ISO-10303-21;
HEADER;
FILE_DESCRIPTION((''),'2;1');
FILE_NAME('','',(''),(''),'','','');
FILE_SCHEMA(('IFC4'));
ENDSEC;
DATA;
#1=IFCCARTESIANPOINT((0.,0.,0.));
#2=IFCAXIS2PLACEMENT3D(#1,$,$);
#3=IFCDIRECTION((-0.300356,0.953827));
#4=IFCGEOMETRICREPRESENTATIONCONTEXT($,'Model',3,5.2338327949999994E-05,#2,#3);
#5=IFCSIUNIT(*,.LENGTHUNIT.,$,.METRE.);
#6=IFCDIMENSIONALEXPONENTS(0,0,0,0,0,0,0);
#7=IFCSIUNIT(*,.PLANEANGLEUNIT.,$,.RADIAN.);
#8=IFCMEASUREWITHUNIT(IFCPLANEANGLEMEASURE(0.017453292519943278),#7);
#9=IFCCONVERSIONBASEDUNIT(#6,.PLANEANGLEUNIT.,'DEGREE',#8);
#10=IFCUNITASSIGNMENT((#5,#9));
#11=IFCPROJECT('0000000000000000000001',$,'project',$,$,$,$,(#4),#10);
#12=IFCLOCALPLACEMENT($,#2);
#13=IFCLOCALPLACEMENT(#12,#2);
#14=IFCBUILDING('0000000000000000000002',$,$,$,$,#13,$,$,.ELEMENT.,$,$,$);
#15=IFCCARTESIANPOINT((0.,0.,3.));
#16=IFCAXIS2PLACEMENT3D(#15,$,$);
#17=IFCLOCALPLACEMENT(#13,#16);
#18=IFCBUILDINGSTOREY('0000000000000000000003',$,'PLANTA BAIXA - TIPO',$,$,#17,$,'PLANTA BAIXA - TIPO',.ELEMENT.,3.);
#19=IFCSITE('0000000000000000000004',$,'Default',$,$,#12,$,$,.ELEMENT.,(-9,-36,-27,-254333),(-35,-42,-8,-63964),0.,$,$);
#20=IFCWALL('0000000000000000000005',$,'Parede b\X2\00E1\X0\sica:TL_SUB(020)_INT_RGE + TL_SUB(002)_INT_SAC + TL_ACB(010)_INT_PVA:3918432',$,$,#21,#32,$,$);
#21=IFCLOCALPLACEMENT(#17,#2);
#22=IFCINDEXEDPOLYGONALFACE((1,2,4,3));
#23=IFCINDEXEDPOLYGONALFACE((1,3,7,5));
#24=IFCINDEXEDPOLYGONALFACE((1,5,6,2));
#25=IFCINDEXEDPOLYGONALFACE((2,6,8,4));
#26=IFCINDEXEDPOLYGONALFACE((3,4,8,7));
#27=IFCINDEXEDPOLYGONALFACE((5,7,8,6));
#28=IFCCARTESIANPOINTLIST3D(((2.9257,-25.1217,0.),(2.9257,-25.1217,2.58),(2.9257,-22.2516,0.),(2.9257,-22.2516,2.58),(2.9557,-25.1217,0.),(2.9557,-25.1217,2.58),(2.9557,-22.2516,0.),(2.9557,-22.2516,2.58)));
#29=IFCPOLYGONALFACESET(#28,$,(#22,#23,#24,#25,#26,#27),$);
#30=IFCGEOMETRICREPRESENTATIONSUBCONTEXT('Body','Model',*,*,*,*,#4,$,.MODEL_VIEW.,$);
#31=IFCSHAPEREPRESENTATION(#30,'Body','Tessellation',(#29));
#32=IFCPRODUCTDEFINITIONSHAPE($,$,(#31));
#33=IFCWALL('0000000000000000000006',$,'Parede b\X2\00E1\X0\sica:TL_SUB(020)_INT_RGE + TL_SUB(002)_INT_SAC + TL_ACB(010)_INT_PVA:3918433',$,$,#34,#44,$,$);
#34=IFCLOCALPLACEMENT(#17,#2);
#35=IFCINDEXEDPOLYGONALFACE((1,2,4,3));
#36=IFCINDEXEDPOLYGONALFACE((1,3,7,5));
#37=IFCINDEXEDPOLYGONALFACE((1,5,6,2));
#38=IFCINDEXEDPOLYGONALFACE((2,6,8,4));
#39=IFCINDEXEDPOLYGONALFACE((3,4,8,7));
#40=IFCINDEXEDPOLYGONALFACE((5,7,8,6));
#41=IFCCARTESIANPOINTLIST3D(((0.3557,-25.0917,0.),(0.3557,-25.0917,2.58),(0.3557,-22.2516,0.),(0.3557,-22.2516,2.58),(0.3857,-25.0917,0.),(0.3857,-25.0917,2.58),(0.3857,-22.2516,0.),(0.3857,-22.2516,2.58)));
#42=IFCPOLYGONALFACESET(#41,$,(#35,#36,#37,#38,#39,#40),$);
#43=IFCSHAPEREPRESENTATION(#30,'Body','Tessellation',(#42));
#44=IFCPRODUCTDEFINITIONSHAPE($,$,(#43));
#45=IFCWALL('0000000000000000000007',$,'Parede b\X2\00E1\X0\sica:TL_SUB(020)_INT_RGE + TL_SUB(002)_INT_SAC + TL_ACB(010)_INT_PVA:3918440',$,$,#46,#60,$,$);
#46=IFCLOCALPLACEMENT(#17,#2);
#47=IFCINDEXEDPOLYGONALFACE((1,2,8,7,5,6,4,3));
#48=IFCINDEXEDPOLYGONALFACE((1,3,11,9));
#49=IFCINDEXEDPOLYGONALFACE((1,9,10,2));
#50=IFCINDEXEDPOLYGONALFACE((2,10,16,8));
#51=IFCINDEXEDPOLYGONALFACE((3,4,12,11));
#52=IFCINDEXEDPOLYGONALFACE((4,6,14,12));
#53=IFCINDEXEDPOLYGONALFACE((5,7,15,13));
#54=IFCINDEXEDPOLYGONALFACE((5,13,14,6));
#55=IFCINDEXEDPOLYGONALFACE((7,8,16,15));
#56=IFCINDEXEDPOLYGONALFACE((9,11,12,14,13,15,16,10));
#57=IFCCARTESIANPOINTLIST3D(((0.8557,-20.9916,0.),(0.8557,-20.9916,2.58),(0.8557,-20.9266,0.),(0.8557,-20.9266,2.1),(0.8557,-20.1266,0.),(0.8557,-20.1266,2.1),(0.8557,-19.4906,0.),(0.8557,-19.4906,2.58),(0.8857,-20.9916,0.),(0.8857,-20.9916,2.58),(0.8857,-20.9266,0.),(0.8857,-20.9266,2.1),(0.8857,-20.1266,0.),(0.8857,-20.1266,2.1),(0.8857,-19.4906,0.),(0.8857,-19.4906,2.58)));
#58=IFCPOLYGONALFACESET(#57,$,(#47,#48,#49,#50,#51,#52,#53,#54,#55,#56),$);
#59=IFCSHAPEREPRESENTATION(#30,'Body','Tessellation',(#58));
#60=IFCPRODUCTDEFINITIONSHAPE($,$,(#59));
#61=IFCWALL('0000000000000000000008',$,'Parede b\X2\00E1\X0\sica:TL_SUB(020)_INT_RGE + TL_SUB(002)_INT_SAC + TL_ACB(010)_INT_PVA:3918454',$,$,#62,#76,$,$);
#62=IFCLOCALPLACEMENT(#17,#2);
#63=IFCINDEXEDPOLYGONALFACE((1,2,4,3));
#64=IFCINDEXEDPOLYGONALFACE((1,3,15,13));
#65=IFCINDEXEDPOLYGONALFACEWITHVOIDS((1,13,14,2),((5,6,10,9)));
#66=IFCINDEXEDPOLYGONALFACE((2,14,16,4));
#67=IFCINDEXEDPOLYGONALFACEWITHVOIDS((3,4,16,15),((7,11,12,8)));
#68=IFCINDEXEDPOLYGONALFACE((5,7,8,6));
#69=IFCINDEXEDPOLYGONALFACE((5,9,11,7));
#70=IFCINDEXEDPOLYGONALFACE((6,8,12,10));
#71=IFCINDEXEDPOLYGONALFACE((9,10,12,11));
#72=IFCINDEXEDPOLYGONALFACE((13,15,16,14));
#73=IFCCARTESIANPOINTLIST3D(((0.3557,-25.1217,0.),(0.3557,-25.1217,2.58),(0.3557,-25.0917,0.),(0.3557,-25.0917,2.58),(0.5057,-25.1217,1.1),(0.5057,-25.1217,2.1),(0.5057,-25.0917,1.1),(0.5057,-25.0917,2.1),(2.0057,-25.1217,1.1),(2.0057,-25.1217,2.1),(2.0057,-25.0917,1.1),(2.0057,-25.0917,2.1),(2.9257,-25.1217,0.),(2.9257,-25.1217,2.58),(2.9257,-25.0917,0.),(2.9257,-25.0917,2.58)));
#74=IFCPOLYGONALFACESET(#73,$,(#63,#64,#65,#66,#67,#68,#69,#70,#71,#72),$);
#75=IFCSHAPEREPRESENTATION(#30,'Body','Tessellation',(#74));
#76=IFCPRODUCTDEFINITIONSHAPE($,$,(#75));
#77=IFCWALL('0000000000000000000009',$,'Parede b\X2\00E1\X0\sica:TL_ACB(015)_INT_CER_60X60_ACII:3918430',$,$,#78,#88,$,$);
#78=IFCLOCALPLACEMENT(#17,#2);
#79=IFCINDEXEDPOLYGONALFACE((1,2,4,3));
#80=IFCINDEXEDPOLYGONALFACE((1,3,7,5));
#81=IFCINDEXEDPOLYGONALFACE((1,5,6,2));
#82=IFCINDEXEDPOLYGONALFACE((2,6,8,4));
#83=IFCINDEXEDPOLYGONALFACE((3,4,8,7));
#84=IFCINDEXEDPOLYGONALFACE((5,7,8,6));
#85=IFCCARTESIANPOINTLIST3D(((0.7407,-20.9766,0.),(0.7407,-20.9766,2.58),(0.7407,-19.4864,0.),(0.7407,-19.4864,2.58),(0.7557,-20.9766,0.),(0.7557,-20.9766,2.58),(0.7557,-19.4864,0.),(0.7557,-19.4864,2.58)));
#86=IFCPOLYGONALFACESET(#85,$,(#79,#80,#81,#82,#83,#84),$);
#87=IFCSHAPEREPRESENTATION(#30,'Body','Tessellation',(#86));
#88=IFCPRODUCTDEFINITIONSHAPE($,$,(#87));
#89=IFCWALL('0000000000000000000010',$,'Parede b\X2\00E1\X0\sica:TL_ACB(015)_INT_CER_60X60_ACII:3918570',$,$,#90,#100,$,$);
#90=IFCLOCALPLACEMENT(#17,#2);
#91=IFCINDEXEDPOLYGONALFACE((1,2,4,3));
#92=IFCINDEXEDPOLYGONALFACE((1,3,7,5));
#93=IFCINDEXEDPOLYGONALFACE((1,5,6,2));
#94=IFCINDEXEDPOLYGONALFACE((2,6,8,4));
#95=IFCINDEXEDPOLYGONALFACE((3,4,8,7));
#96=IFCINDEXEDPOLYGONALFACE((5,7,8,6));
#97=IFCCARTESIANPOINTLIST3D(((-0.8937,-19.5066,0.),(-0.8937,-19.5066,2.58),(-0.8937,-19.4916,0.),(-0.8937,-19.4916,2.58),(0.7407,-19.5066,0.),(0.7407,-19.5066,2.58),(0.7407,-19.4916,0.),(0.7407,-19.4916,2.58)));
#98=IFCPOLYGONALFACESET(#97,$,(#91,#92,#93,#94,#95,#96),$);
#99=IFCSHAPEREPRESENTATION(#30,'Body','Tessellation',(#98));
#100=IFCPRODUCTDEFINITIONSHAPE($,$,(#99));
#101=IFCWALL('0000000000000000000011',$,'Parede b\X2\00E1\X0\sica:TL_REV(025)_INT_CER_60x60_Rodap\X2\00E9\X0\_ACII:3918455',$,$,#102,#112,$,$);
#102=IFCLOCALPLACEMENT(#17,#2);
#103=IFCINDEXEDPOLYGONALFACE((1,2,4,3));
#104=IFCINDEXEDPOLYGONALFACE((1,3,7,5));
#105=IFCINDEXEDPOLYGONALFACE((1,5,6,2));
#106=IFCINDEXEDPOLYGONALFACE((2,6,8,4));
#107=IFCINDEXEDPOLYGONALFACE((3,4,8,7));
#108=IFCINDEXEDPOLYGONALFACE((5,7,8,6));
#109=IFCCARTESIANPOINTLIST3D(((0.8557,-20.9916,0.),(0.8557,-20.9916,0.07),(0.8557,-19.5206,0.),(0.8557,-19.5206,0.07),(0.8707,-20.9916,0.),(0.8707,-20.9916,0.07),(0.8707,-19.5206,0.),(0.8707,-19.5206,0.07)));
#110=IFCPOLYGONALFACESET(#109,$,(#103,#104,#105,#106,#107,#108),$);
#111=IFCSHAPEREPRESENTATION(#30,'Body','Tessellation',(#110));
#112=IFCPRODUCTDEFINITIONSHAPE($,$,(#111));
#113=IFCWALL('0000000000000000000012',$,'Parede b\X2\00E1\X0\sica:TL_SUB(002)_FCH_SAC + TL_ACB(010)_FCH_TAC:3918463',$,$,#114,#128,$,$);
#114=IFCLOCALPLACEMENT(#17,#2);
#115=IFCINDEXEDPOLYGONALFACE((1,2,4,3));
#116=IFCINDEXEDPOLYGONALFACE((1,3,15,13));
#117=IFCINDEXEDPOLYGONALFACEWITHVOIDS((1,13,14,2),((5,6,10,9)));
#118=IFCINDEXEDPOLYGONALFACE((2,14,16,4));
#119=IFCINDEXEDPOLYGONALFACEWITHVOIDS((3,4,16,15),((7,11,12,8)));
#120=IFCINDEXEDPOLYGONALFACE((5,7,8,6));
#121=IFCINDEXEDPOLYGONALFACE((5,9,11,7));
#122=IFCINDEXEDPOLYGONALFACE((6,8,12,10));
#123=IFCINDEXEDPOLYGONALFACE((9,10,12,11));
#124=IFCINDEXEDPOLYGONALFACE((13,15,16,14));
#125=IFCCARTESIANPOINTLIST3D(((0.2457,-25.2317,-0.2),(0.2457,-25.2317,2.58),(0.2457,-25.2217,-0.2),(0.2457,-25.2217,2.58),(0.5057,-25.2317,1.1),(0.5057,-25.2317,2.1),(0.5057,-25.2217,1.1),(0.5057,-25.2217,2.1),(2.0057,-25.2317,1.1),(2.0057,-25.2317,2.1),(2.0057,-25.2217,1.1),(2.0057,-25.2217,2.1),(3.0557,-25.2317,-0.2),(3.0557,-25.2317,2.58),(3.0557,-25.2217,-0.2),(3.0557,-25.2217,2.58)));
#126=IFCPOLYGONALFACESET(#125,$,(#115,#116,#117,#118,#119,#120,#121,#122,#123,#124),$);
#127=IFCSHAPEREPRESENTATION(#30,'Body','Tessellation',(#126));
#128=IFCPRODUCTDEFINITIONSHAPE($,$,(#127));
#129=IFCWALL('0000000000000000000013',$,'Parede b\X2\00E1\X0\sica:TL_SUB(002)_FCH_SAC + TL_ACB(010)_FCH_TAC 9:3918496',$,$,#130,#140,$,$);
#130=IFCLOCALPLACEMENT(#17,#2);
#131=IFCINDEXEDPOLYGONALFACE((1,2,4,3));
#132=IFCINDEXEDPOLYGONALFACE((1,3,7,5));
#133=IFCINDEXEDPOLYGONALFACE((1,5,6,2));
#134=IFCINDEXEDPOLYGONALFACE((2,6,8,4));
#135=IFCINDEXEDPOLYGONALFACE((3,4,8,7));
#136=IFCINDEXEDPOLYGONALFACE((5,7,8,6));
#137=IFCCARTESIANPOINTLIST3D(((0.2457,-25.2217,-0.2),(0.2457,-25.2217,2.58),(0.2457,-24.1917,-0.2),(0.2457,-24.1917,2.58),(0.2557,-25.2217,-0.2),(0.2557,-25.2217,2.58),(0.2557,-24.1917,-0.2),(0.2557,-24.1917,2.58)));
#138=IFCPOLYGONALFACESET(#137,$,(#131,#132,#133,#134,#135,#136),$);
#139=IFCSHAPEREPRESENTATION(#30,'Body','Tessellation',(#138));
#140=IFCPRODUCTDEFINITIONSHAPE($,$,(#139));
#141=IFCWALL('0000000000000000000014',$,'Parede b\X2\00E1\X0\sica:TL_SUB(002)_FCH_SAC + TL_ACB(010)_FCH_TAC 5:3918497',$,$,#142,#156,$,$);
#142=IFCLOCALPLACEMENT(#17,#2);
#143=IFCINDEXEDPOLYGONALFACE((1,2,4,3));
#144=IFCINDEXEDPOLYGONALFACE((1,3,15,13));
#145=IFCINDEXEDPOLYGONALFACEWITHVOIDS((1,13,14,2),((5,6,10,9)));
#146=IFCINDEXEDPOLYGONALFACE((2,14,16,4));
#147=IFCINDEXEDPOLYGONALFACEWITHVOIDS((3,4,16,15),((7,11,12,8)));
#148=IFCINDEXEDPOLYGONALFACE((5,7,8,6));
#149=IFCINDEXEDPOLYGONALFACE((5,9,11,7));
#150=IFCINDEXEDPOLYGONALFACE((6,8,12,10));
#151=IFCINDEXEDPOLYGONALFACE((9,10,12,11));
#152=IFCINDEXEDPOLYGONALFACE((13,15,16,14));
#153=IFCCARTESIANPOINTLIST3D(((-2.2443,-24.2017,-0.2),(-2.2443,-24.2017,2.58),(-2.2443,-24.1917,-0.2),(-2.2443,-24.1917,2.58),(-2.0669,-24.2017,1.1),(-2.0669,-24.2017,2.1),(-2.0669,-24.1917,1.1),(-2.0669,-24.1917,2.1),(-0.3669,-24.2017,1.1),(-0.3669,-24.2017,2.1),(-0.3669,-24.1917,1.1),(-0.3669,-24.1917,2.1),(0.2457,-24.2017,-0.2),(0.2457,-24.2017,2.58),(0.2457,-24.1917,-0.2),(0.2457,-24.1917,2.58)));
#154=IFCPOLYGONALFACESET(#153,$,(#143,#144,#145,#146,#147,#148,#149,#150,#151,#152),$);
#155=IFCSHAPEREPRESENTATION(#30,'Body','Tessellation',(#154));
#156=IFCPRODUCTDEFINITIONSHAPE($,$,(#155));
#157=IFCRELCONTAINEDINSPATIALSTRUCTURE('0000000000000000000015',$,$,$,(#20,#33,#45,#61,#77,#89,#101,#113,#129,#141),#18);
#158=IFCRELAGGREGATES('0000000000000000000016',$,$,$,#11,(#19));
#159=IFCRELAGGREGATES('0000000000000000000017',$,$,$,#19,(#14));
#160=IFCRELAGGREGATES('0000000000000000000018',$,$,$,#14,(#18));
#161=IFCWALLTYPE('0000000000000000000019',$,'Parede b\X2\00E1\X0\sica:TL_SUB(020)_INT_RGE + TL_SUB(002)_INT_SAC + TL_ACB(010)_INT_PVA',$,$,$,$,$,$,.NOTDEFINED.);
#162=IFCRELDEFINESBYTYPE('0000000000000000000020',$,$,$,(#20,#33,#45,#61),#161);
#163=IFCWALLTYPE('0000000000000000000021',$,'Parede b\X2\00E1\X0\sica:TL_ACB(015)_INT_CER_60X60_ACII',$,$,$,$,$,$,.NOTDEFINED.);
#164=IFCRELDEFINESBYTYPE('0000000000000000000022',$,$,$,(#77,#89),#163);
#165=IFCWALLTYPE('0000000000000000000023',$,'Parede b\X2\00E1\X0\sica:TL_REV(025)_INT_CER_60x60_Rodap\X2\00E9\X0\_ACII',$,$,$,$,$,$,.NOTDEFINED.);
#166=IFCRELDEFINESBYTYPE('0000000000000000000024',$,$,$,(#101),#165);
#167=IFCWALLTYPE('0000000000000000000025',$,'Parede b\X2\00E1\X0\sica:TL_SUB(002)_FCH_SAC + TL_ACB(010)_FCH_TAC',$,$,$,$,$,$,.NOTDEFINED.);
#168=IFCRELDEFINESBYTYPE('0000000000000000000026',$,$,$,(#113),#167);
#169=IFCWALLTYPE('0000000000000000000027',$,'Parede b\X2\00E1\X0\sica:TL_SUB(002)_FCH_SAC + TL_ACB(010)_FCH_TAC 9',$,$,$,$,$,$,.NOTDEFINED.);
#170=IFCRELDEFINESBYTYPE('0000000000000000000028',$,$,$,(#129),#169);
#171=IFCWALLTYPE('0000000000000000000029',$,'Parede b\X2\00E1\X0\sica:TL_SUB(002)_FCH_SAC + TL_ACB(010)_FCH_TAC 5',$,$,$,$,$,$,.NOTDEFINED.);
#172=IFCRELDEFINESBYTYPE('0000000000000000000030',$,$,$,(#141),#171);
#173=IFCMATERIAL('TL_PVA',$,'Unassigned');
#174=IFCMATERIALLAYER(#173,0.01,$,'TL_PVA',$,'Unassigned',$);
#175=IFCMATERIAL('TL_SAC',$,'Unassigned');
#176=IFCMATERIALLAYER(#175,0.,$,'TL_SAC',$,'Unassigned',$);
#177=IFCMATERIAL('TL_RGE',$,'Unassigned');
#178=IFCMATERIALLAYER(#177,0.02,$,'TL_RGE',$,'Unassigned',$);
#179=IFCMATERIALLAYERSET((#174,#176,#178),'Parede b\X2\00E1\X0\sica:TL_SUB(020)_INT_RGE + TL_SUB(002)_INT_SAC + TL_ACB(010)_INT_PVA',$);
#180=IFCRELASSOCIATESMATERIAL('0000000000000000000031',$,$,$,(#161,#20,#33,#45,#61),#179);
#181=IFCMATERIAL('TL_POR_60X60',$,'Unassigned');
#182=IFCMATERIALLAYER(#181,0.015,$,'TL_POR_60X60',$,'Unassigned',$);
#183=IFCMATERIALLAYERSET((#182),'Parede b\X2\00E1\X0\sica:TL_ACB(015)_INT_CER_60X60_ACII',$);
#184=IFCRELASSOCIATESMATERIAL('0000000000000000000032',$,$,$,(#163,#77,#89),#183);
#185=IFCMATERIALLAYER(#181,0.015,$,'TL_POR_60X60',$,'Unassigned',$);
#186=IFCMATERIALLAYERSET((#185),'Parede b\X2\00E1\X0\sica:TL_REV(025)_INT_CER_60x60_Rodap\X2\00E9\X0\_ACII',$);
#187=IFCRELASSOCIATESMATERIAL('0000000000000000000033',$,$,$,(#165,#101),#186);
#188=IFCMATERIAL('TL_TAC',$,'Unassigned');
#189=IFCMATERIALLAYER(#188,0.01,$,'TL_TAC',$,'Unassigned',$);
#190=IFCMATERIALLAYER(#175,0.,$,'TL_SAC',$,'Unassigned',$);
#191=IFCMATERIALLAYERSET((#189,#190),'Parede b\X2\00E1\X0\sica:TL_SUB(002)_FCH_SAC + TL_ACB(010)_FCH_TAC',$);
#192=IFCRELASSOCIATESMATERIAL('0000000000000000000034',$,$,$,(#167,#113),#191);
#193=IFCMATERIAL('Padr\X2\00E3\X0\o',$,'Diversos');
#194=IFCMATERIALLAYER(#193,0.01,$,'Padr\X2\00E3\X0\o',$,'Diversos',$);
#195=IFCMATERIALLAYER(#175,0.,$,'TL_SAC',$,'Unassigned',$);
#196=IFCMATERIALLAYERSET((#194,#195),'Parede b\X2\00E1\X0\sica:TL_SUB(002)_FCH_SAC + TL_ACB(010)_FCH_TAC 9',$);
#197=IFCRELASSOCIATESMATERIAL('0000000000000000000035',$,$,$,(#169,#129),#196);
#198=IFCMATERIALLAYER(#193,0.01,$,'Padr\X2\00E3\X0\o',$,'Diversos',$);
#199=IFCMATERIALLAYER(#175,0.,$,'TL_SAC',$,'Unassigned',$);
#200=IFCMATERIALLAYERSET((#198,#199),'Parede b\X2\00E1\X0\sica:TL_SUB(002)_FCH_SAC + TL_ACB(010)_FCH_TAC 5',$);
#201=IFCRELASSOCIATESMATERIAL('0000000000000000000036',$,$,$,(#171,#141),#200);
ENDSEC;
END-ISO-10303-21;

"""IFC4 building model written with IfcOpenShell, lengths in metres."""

from ifc_helpers import new_model, entity, si_unit, converted_unit, direction, frame, frame_2d, origin, place, context, subcontext, project, spatial, rectangle, extrude, material, layer, layer_set, layer_usage, type_object, element, save


model = new_model("IFC4")

# Units and contexts
model_context = context("Model", 3, precision=5.2338327949999994e-05, world=origin(), true_north=direction((-0.300356, 0.953827)))
body_context = subcontext(model_context, "Body", "Model", "MODEL_VIEW")
ifc_project = project(units=[si_unit("LENGTHUNIT", "METRE"), converted_unit("PLANEANGLEUNIT", "DEGREE", entity("IfcPlaneAngleMeasure", 0.017453292519943278), si_unit("PLANEANGLEUNIT", "RADIAN"), dimensions=[0, 0, 0, 0, 0, 0, 0])], contexts=[model_context])

# Site, building, storey
site_placement = place(None, origin())
site = spatial("IfcSite", under=ifc_project, at=site_placement, Name="Default", CompositionType="ELEMENT", RefLatitude=(-9, -36, -27, -254333), RefLongitude=(-35, -42, -8, -63964), RefElevation=0.0)
building_placement = place(site_placement, origin())
building = spatial("IfcBuilding", under=site, at=building_placement, CompositionType="ELEMENT")
storey_placement = place(building_placement, frame((0.0, 0.0, 3.0)))
storey = spatial("IfcBuildingStorey", under=building, at=storey_placement, Name="PLANTA BAIXA - TIPO", LongName="PLANTA BAIXA - TIPO", CompositionType="ELEMENT", Elevation=3.0)

# Shared definitions
ifc_material_1 = material(Name="TL_PVA", Category="Unassigned")
ifc_layer_1 = layer(ifc_material_1, 0.01, Name="TL_PVA", Category="Unassigned")
ifc_material_2 = material(Name="TL_SAC", Category="Unassigned")
ifc_layer_2 = layer(ifc_material_2, 0.0, Name="TL_SAC", Category="Unassigned")
ifc_material_3 = material(Name="TL_RGE", Category="Unassigned")
ifc_layer_3 = layer(ifc_material_3, 0.02, Name="TL_RGE", Category="Unassigned")
ifc_layer_set_1 = layer_set([ifc_layer_1, ifc_layer_2, ifc_layer_3], Name="Parede básica:TL_SUB(020)_INT_RGE + TL_SUB(002)_INT_SAC + TL_ACB(010)_INT_PVA")
wall_type_1 = type_object("IfcWallType", Name="Parede básica:TL_SUB(020)_INT_RGE + TL_SUB(002)_INT_SAC + TL_ACB(010)_INT_PVA", PredefinedType="NOTDEFINED", material=ifc_layer_set_1)

# Walls
ifc_layer_usage_1 = layer_usage(ifc_layer_set_1, "AXIS2", "POSITIVE", -0.015)
wall_1_placement = place(storey_placement, frame((2.9407, -22.2516, 0.0), z_axis=(0.0, 0.0, 1.0), x_axis=(0.0, -1.0, 0.0)))
element("IfcWall", 1, at=wall_1_placement, inside=storey, type_object=wall_type_1, material=ifc_layer_usage_1, Name="Parede básica:TL_SUB(020)_INT_RGE + TL_SUB(002)_INT_SAC + TL_ACB(010)_INT_PVA:3918432", context=body_context, shape_type="SweptSolid", body=[
    extrude(rectangle(XDim=2.8701, YDim=0.03, at=frame_2d((1.4351, 0.0), x_axis=(-1.0, 0.0))), origin(), (0.0, 0.0, 1.0), 2.58),
])
ifc_layer_usage_2 = layer_usage(ifc_layer_set_1, "AXIS2", "POSITIVE", -0.015)
wall_2_placement = place(storey_placement, frame((0.3707, -25.0917, 0.0), z_axis=(0.0, 0.0, 1.0), x_axis=(0.0, 1.0, 0.0)))
element("IfcWall", 2, at=wall_2_placement, inside=storey, type_object=wall_type_1, material=ifc_layer_usage_2, Name="Parede básica:TL_SUB(020)_INT_RGE + TL_SUB(002)_INT_SAC + TL_ACB(010)_INT_PVA:3918433", context=body_context, shape_type="SweptSolid", body=[
    extrude(rectangle(XDim=2.8401, YDim=0.03, at=frame_2d((1.4201, 0.0), x_axis=(-1.0, 0.0))), origin(), (0.0, 0.0, 1.0), 2.58),
])

# Walls, openings
ifc_layer_usage_3 = layer_usage(ifc_layer_set_1, "AXIS2", "POSITIVE", -0.015)
wall_3_placement = place(storey_placement, frame((0.8707, -20.9916, 0.0), z_axis=(0.0, 0.0, 1.0), x_axis=(0.0, 1.0, 0.0)))
wall_3 = element("IfcWall", 3, at=wall_3_placement, inside=storey, type_object=wall_type_1, material=ifc_layer_usage_3, Name="Parede básica:TL_SUB(020)_INT_RGE + TL_SUB(002)_INT_SAC + TL_ACB(010)_INT_PVA:3918440", context=body_context, shape_type="SweptSolid", body=[
    extrude(rectangle(XDim=1.501, YDim=0.03, at=frame_2d((0.7505, 0.0), x_axis=(-1.0, 0.0))), origin(), (0.0, 0.0, 1.0), 2.58),
])
opening_1_placement = place(wall_3_placement, frame((0.065, -0.015, 0.0)))
element("IfcOpeningElement", 4, at=opening_1_placement, cuts=wall_3, PredefinedType="OPENING", context=body_context, shape_type="SweptSolid", body=[
    extrude(rectangle(XDim=2.1, YDim=0.8, at=frame_2d((1.05, 0.4), x_axis=(1.0, 0.0))), frame((0.0, 0.0, 0.0), z_axis=(0.0, 1.0, 0.0), x_axis=(0.0, 0.0, 1.0)), (0.0, 0.0, 1.0), 0.03),
])
ifc_layer_usage_4 = layer_usage(ifc_layer_set_1, "AXIS2", "POSITIVE", -0.015)
wall_4_placement = place(storey_placement, frame((2.9257, -25.1067, 0.0), z_axis=(0.0, 0.0, 1.0), x_axis=(-1.0, 0.0, 0.0)))
wall_4 = element("IfcWall", 5, at=wall_4_placement, inside=storey, type_object=wall_type_1, material=ifc_layer_usage_4, Name="Parede básica:TL_SUB(020)_INT_RGE + TL_SUB(002)_INT_SAC + TL_ACB(010)_INT_PVA:3918454", context=body_context, shape_type="SweptSolid", body=[
    extrude(rectangle(XDim=2.57, YDim=0.03, at=frame_2d((1.285, 0.0), x_axis=(-1.0, 0.0))), origin(), (0.0, 0.0, 1.0), 2.58),
])
opening_2_placement = place(wall_4_placement, frame((2.9257, -25.1067, 1.1)))
element("IfcOpeningElement", 6, at=opening_2_placement, cuts=wall_4, PredefinedType="OPENING", context=body_context, shape_type="SweptSolid", body=[
    extrude(rectangle(XDim=1.0, YDim=1.5, at=frame_2d((0.0, 0.0), x_axis=(0.0, 1.0))), frame((-1.2557, 23.5977, 0.5), z_axis=(0.0, 1.0, 0.0), x_axis=(1.0, 0.0, 0.0)), (0.0, 0.0, 1.0), 3.048),
])

# Walls
ifc_material_4 = material(Name="TL_POR_60X60", Category="Unassigned")
ifc_layer_4 = layer(ifc_material_4, 0.015, Name="TL_POR_60X60", Category="Unassigned")
ifc_layer_set_2 = layer_set([ifc_layer_4], Name="Parede básica:TL_ACB(015)_INT_CER_60X60_ACII")
ifc_layer_usage_5 = layer_usage(ifc_layer_set_2, "AXIS2", "POSITIVE", -0.0075)
wall_type_2 = type_object("IfcWallType", Name="Parede básica:TL_ACB(015)_INT_CER_60X60_ACII", PredefinedType="NOTDEFINED", material=ifc_layer_set_2)
wall_5_placement = place(storey_placement, frame((0.7482, -19.4864, 0.0), z_axis=(0.0, 0.0, 1.0), x_axis=(0.0, -1.0, 0.0)))
element("IfcWall", 7, at=wall_5_placement, inside=storey, type_object=wall_type_2, material=ifc_layer_usage_5, Name="Parede básica:TL_ACB(015)_INT_CER_60X60_ACII:3918430", context=body_context, shape_type="SweptSolid", body=[
    extrude(rectangle(XDim=1.4902, YDim=0.015, at=frame_2d((0.7451, 0.0), x_axis=(-1.0, 0.0))), origin(), (0.0, 0.0, 1.0), 2.58),
])
ifc_layer_usage_6 = layer_usage(ifc_layer_set_2, "AXIS2", "NEGATIVE", 0.0075)
wall_6_placement = place(storey_placement, frame((0.7407, -19.4991, 0.0), z_axis=(0.0, 0.0, 1.0), x_axis=(-1.0, 0.0, 0.0)))
element("IfcWall", 8, at=wall_6_placement, inside=storey, type_object=wall_type_2, material=ifc_layer_usage_6, Name="Parede básica:TL_ACB(015)_INT_CER_60X60_ACII:3918570", context=body_context, shape_type="SweptSolid", body=[
    extrude(rectangle(XDim=1.6345, YDim=0.015, at=frame_2d((0.8172, 0.0), x_axis=(-1.0, 0.0))), origin(), (0.0, 0.0, 1.0), 2.58),
])
ifc_layer_5 = layer(ifc_material_4, 0.015, Name="TL_POR_60X60", Category="Unassigned")
ifc_layer_set_3 = layer_set([ifc_layer_5], Name="Parede básica:TL_REV(025)_INT_CER_60x60_Rodapé_ACII")
ifc_layer_usage_7 = layer_usage(ifc_layer_set_3, "AXIS2", "NEGATIVE", 0.0075)
wall_type_3 = type_object("IfcWallType", Name="Parede básica:TL_REV(025)_INT_CER_60x60_Rodapé_ACII", PredefinedType="NOTDEFINED", material=ifc_layer_set_3)
wall_7_placement = place(storey_placement, frame((0.8632, -19.5206, 0.0), z_axis=(0.0, 0.0, 1.0), x_axis=(0.0, -1.0, 0.0)))
element("IfcWall", 9, at=wall_7_placement, inside=storey, type_object=wall_type_3, material=ifc_layer_usage_7, Name="Parede básica:TL_REV(025)_INT_CER_60x60_Rodapé_ACII:3918455", context=body_context, shape_type="SweptSolid", body=[
    extrude(rectangle(XDim=1.471, YDim=0.015, at=frame_2d((0.7355, 0.0), x_axis=(-1.0, 0.0))), origin(), (0.0, 0.0, 1.0), 0.07),
])

# Wall, opening
ifc_material_5 = material(Name="TL_TAC", Category="Unassigned")
ifc_layer_6 = layer(ifc_material_5, 0.01, Name="TL_TAC", Category="Unassigned")
ifc_layer_7 = layer(ifc_material_2, 0.0, Name="TL_SAC", Category="Unassigned")
ifc_layer_set_4 = layer_set([ifc_layer_6, ifc_layer_7], Name="Parede básica:TL_SUB(002)_FCH_SAC + TL_ACB(010)_FCH_TAC")
ifc_layer_usage_8 = layer_usage(ifc_layer_set_4, "AXIS2", "NEGATIVE", 0.005)
wall_type_4 = type_object("IfcWallType", Name="Parede básica:TL_SUB(002)_FCH_SAC + TL_ACB(010)_FCH_TAC", PredefinedType="NOTDEFINED", material=ifc_layer_set_4)
wall_8_placement = place(storey_placement, frame((3.0557, -25.2267, -0.2), z_axis=(0.0, 0.0, 1.0), x_axis=(-1.0, 0.0, 0.0)))
wall_8 = element("IfcWall", 10, at=wall_8_placement, inside=storey, type_object=wall_type_4, material=ifc_layer_usage_8, Name="Parede básica:TL_SUB(002)_FCH_SAC + TL_ACB(010)_FCH_TAC:3918463", context=body_context, shape_type="SweptSolid", body=[
    extrude(rectangle(XDim=2.81, YDim=0.01, at=frame_2d((1.405, 0.0), x_axis=(-1.0, 0.0))), origin(), (0.0, 0.0, 1.0), 2.78),
])
opening_3_placement = place(wall_8_placement, frame((3.0557, -25.2267, 1.3)))
element("IfcOpeningElement", 11, at=opening_3_placement, cuts=wall_8, PredefinedType="OPENING", context=body_context, shape_type="SweptSolid", body=[
    extrude(rectangle(XDim=1.0, YDim=1.5, at=frame_2d((0.0, 0.0), x_axis=(0.0, 1.0))), frame((-1.2557, 23.5977, 0.5), z_axis=(0.0, 1.0, 0.0), x_axis=(1.0, 0.0, 0.0)), (0.0, 0.0, 1.0), 3.048),
])

# Wall
ifc_material_6 = material(Name="Padrão", Category="Diversos")
ifc_layer_8 = layer(ifc_material_6, 0.01, Name="Padrão", Category="Diversos")
ifc_layer_9 = layer(ifc_material_2, 0.0, Name="TL_SAC", Category="Unassigned")
ifc_layer_set_5 = layer_set([ifc_layer_8, ifc_layer_9], Name="Parede básica:TL_SUB(002)_FCH_SAC + TL_ACB(010)_FCH_TAC 9")
ifc_layer_usage_9 = layer_usage(ifc_layer_set_5, "AXIS2", "POSITIVE", -0.005)
wall_type_5 = type_object("IfcWallType", Name="Parede básica:TL_SUB(002)_FCH_SAC + TL_ACB(010)_FCH_TAC 9", PredefinedType="NOTDEFINED", material=ifc_layer_set_5)
wall_9_placement = place(storey_placement, frame((0.2507, -25.2217, -0.2), z_axis=(0.0, 0.0, 1.0), x_axis=(0.0, 1.0, 0.0)))
element("IfcWall", 12, at=wall_9_placement, inside=storey, type_object=wall_type_5, material=ifc_layer_usage_9, Name="Parede básica:TL_SUB(002)_FCH_SAC + TL_ACB(010)_FCH_TAC 9:3918496", context=body_context, shape_type="SweptSolid", body=[
    extrude(rectangle(XDim=1.03, YDim=0.01, at=frame_2d((0.515, 0.0), x_axis=(-1.0, 0.0))), origin(), (0.0, 0.0, 1.0), 2.78),
])

# Wall, opening
ifc_layer_10 = layer(ifc_material_6, 0.01, Name="Padrão", Category="Diversos")
ifc_layer_11 = layer(ifc_material_2, 0.0, Name="TL_SAC", Category="Unassigned")
ifc_layer_set_6 = layer_set([ifc_layer_10, ifc_layer_11], Name="Parede básica:TL_SUB(002)_FCH_SAC + TL_ACB(010)_FCH_TAC 5")
ifc_layer_usage_10 = layer_usage(ifc_layer_set_6, "AXIS2", "POSITIVE", -0.005)
wall_type_6 = type_object("IfcWallType", Name="Parede básica:TL_SUB(002)_FCH_SAC + TL_ACB(010)_FCH_TAC 5", PredefinedType="NOTDEFINED", material=ifc_layer_set_6)
wall_10_placement = place(storey_placement, frame((0.2457, -24.1967, -0.2), z_axis=(0.0, 0.0, 1.0), x_axis=(-1.0, 0.0, 0.0)))
wall_10 = element("IfcWall", 13, at=wall_10_placement, inside=storey, type_object=wall_type_6, material=ifc_layer_usage_10, Name="Parede básica:TL_SUB(002)_FCH_SAC + TL_ACB(010)_FCH_TAC 5:3918497", context=body_context, shape_type="SweptSolid", body=[
    extrude(rectangle(XDim=2.49, YDim=0.01, at=frame_2d((1.245, 0.0), x_axis=(-1.0, 0.0))), origin(), (0.0, 0.0, 1.0), 2.78),
])
opening_4_placement = place(wall_10_placement, frame((0.2457, -24.1967, 1.3)))
element("IfcOpeningElement", 14, at=opening_4_placement, cuts=wall_10, PredefinedType="OPENING", context=body_context, shape_type="SweptSolid", body=[
    extrude(rectangle(XDim=1.0, YDim=1.7, at=frame_2d((0.0, 0.0), x_axis=(0.0, 1.0))), frame((1.2169, 22.5677, 0.5), z_axis=(0.0, 1.0, 0.0), x_axis=(1.0, 0.0, 0.0)), (0.0, 0.0, 1.0), 3.048),
])

save(model, "model.ifc")
